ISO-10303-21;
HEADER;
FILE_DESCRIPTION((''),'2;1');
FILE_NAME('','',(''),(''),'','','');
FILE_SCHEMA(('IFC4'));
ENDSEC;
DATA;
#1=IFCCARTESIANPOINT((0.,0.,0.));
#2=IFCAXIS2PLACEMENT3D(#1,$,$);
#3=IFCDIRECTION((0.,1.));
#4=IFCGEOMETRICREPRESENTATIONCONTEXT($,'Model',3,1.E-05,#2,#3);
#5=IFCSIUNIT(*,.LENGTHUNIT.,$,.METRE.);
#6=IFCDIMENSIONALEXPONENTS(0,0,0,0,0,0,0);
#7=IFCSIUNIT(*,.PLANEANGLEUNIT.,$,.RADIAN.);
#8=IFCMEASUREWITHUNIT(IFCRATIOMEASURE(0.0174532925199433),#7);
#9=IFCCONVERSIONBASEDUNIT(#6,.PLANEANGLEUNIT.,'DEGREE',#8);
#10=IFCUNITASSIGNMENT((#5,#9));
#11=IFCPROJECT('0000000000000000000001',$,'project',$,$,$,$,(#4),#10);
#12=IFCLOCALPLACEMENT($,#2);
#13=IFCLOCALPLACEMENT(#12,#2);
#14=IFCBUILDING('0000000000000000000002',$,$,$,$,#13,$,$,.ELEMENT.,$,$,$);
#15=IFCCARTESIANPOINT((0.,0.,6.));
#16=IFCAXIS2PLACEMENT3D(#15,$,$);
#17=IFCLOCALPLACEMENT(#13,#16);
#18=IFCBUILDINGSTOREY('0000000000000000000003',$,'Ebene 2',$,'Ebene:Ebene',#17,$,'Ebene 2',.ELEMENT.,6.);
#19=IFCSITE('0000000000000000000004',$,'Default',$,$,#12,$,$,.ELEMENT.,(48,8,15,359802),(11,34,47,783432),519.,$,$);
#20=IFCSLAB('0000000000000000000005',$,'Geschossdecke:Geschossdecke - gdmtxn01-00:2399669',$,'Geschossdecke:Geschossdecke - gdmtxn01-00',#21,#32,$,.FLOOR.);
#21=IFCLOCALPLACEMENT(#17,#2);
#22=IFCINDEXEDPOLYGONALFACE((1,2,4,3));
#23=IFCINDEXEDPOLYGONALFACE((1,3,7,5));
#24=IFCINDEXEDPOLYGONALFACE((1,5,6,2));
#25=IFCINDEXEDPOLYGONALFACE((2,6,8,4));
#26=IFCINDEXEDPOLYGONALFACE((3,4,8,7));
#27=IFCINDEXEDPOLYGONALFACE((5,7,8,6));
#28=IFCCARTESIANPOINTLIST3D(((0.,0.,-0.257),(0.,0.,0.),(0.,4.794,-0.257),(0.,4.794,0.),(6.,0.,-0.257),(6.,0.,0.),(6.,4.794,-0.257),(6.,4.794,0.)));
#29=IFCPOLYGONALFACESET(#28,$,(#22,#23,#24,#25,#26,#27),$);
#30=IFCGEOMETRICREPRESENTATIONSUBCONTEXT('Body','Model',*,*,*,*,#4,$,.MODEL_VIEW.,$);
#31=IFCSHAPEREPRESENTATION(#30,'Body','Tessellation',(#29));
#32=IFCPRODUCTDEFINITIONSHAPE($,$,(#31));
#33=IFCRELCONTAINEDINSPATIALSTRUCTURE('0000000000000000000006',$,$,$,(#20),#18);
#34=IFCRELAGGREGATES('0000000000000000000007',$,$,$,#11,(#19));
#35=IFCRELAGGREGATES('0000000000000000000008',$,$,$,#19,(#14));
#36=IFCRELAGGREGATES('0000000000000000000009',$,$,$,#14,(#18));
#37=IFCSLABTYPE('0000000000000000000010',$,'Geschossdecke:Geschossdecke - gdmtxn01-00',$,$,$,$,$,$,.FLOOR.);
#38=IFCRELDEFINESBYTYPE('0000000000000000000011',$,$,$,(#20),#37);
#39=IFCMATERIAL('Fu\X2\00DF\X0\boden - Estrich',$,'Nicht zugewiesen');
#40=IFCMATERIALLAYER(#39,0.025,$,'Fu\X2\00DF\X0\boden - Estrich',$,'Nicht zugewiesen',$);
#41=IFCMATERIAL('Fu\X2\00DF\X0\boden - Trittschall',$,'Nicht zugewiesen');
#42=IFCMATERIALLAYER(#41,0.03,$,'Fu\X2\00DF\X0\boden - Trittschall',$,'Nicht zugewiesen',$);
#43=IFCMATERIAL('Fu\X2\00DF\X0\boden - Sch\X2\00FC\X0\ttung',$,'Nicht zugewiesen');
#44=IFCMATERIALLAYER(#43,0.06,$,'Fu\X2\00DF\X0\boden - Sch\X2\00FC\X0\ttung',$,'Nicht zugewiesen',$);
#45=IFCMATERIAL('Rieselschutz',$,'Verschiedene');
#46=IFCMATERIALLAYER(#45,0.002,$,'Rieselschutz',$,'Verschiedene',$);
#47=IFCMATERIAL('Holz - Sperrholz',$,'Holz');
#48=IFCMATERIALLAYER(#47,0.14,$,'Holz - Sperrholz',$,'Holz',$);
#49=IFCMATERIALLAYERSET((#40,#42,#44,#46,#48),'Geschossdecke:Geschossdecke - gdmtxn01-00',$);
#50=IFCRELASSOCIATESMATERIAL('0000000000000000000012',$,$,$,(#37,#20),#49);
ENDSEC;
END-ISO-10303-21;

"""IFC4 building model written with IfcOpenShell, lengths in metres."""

from ifc_helpers import new_model, entity, si_unit, converted_unit, direction, frame, frame_2d, origin, place, context, subcontext, project, spatial, rectangle, extrude, material, layer, layer_set, layer_usage, type_object, element, save


model = new_model("IFC4")

# Units and contexts
model_context = context("Model", 3, precision=1e-05, world=origin(), true_north=direction((0.0, 1.0)))
body_context = subcontext(model_context, "Body", "Model", "MODEL_VIEW")
ifc_project = project(units=[si_unit("LENGTHUNIT", "METRE"), converted_unit("PLANEANGLEUNIT", "DEGREE", entity("IfcRatioMeasure", 0.0174532925199433), si_unit("PLANEANGLEUNIT", "RADIAN"), dimensions=[0, 0, 0, 0, 0, 0, 0])], contexts=[model_context])

# Site, building, storey
site_placement = place(None, frame((0.0, 0.0, 0.0)))
site = spatial("IfcSite", under=ifc_project, at=site_placement, Name="Default", CompositionType="ELEMENT", RefLatitude=(48, 8, 15, 359802), RefLongitude=(11, 34, 47, 783432), RefElevation=519.0)
building_placement = place(site_placement, origin())
building = spatial("IfcBuilding", under=site, at=building_placement, CompositionType="ELEMENT")
storey_placement = place(building_placement, frame((0.0, 0.0, 6.0)))
storey = spatial("IfcBuildingStorey", under=building, at=storey_placement, Name="Ebene 2", ObjectType="Ebene:Ebene", LongName="Ebene 2", CompositionType="ELEMENT", Elevation=6.0)

# Slab
ifc_material_1 = material(Name="Fußboden - Estrich", Category="Nicht zugewiesen")
ifc_layer_1 = layer(ifc_material_1, 0.025, Name="Fußboden - Estrich", Category="Nicht zugewiesen")
ifc_material_2 = material(Name="Fußboden - Trittschall", Category="Nicht zugewiesen")
ifc_layer_2 = layer(ifc_material_2, 0.03, Name="Fußboden - Trittschall", Category="Nicht zugewiesen")
ifc_material_3 = material(Name="Fußboden - Schüttung", Category="Nicht zugewiesen")
ifc_layer_3 = layer(ifc_material_3, 0.06, Name="Fußboden - Schüttung", Category="Nicht zugewiesen")
ifc_material_4 = material(Name="Rieselschutz", Category="Verschiedene")
ifc_layer_4 = layer(ifc_material_4, 0.002, Name="Rieselschutz", Category="Verschiedene")
ifc_material_5 = material(Name="Holz - Sperrholz", Category="Holz")
ifc_layer_5 = layer(ifc_material_5, 0.14, Name="Holz - Sperrholz", Category="Holz")
ifc_layer_set = layer_set([ifc_layer_1, ifc_layer_2, ifc_layer_3, ifc_layer_4, ifc_layer_5], Name="Geschossdecke:Geschossdecke - gdmtxn01-00")
ifc_layer_usage = layer_usage(ifc_layer_set, "AXIS3", "POSITIVE", 0.0)
slab_type = type_object("IfcSlabType", Name="Geschossdecke:Geschossdecke - gdmtxn01-00", PredefinedType="FLOOR", material=ifc_layer_set)
slab_placement = place(storey_placement, origin())
element("IfcSlab", 1, at=slab_placement, inside=storey, type_object=slab_type, material=ifc_layer_usage, Name="Geschossdecke:Geschossdecke - gdmtxn01-00:2399669", ObjectType="Geschossdecke:Geschossdecke - gdmtxn01-00", PredefinedType="FLOOR", context=body_context, shape_type="SweptSolid", body=[
    extrude(rectangle(XDim=4.794, YDim=6.0, at=frame_2d((0.0, 0.0), x_axis=(1.0, 0.0))), frame((3.0, 2.397, 0.0), z_axis=(0.0, 0.0, -1.0), x_axis=(0.0, 1.0, 0.0)), (0.0, 0.0, 1.0), 0.257),
])

save(model, "model.ifc")
